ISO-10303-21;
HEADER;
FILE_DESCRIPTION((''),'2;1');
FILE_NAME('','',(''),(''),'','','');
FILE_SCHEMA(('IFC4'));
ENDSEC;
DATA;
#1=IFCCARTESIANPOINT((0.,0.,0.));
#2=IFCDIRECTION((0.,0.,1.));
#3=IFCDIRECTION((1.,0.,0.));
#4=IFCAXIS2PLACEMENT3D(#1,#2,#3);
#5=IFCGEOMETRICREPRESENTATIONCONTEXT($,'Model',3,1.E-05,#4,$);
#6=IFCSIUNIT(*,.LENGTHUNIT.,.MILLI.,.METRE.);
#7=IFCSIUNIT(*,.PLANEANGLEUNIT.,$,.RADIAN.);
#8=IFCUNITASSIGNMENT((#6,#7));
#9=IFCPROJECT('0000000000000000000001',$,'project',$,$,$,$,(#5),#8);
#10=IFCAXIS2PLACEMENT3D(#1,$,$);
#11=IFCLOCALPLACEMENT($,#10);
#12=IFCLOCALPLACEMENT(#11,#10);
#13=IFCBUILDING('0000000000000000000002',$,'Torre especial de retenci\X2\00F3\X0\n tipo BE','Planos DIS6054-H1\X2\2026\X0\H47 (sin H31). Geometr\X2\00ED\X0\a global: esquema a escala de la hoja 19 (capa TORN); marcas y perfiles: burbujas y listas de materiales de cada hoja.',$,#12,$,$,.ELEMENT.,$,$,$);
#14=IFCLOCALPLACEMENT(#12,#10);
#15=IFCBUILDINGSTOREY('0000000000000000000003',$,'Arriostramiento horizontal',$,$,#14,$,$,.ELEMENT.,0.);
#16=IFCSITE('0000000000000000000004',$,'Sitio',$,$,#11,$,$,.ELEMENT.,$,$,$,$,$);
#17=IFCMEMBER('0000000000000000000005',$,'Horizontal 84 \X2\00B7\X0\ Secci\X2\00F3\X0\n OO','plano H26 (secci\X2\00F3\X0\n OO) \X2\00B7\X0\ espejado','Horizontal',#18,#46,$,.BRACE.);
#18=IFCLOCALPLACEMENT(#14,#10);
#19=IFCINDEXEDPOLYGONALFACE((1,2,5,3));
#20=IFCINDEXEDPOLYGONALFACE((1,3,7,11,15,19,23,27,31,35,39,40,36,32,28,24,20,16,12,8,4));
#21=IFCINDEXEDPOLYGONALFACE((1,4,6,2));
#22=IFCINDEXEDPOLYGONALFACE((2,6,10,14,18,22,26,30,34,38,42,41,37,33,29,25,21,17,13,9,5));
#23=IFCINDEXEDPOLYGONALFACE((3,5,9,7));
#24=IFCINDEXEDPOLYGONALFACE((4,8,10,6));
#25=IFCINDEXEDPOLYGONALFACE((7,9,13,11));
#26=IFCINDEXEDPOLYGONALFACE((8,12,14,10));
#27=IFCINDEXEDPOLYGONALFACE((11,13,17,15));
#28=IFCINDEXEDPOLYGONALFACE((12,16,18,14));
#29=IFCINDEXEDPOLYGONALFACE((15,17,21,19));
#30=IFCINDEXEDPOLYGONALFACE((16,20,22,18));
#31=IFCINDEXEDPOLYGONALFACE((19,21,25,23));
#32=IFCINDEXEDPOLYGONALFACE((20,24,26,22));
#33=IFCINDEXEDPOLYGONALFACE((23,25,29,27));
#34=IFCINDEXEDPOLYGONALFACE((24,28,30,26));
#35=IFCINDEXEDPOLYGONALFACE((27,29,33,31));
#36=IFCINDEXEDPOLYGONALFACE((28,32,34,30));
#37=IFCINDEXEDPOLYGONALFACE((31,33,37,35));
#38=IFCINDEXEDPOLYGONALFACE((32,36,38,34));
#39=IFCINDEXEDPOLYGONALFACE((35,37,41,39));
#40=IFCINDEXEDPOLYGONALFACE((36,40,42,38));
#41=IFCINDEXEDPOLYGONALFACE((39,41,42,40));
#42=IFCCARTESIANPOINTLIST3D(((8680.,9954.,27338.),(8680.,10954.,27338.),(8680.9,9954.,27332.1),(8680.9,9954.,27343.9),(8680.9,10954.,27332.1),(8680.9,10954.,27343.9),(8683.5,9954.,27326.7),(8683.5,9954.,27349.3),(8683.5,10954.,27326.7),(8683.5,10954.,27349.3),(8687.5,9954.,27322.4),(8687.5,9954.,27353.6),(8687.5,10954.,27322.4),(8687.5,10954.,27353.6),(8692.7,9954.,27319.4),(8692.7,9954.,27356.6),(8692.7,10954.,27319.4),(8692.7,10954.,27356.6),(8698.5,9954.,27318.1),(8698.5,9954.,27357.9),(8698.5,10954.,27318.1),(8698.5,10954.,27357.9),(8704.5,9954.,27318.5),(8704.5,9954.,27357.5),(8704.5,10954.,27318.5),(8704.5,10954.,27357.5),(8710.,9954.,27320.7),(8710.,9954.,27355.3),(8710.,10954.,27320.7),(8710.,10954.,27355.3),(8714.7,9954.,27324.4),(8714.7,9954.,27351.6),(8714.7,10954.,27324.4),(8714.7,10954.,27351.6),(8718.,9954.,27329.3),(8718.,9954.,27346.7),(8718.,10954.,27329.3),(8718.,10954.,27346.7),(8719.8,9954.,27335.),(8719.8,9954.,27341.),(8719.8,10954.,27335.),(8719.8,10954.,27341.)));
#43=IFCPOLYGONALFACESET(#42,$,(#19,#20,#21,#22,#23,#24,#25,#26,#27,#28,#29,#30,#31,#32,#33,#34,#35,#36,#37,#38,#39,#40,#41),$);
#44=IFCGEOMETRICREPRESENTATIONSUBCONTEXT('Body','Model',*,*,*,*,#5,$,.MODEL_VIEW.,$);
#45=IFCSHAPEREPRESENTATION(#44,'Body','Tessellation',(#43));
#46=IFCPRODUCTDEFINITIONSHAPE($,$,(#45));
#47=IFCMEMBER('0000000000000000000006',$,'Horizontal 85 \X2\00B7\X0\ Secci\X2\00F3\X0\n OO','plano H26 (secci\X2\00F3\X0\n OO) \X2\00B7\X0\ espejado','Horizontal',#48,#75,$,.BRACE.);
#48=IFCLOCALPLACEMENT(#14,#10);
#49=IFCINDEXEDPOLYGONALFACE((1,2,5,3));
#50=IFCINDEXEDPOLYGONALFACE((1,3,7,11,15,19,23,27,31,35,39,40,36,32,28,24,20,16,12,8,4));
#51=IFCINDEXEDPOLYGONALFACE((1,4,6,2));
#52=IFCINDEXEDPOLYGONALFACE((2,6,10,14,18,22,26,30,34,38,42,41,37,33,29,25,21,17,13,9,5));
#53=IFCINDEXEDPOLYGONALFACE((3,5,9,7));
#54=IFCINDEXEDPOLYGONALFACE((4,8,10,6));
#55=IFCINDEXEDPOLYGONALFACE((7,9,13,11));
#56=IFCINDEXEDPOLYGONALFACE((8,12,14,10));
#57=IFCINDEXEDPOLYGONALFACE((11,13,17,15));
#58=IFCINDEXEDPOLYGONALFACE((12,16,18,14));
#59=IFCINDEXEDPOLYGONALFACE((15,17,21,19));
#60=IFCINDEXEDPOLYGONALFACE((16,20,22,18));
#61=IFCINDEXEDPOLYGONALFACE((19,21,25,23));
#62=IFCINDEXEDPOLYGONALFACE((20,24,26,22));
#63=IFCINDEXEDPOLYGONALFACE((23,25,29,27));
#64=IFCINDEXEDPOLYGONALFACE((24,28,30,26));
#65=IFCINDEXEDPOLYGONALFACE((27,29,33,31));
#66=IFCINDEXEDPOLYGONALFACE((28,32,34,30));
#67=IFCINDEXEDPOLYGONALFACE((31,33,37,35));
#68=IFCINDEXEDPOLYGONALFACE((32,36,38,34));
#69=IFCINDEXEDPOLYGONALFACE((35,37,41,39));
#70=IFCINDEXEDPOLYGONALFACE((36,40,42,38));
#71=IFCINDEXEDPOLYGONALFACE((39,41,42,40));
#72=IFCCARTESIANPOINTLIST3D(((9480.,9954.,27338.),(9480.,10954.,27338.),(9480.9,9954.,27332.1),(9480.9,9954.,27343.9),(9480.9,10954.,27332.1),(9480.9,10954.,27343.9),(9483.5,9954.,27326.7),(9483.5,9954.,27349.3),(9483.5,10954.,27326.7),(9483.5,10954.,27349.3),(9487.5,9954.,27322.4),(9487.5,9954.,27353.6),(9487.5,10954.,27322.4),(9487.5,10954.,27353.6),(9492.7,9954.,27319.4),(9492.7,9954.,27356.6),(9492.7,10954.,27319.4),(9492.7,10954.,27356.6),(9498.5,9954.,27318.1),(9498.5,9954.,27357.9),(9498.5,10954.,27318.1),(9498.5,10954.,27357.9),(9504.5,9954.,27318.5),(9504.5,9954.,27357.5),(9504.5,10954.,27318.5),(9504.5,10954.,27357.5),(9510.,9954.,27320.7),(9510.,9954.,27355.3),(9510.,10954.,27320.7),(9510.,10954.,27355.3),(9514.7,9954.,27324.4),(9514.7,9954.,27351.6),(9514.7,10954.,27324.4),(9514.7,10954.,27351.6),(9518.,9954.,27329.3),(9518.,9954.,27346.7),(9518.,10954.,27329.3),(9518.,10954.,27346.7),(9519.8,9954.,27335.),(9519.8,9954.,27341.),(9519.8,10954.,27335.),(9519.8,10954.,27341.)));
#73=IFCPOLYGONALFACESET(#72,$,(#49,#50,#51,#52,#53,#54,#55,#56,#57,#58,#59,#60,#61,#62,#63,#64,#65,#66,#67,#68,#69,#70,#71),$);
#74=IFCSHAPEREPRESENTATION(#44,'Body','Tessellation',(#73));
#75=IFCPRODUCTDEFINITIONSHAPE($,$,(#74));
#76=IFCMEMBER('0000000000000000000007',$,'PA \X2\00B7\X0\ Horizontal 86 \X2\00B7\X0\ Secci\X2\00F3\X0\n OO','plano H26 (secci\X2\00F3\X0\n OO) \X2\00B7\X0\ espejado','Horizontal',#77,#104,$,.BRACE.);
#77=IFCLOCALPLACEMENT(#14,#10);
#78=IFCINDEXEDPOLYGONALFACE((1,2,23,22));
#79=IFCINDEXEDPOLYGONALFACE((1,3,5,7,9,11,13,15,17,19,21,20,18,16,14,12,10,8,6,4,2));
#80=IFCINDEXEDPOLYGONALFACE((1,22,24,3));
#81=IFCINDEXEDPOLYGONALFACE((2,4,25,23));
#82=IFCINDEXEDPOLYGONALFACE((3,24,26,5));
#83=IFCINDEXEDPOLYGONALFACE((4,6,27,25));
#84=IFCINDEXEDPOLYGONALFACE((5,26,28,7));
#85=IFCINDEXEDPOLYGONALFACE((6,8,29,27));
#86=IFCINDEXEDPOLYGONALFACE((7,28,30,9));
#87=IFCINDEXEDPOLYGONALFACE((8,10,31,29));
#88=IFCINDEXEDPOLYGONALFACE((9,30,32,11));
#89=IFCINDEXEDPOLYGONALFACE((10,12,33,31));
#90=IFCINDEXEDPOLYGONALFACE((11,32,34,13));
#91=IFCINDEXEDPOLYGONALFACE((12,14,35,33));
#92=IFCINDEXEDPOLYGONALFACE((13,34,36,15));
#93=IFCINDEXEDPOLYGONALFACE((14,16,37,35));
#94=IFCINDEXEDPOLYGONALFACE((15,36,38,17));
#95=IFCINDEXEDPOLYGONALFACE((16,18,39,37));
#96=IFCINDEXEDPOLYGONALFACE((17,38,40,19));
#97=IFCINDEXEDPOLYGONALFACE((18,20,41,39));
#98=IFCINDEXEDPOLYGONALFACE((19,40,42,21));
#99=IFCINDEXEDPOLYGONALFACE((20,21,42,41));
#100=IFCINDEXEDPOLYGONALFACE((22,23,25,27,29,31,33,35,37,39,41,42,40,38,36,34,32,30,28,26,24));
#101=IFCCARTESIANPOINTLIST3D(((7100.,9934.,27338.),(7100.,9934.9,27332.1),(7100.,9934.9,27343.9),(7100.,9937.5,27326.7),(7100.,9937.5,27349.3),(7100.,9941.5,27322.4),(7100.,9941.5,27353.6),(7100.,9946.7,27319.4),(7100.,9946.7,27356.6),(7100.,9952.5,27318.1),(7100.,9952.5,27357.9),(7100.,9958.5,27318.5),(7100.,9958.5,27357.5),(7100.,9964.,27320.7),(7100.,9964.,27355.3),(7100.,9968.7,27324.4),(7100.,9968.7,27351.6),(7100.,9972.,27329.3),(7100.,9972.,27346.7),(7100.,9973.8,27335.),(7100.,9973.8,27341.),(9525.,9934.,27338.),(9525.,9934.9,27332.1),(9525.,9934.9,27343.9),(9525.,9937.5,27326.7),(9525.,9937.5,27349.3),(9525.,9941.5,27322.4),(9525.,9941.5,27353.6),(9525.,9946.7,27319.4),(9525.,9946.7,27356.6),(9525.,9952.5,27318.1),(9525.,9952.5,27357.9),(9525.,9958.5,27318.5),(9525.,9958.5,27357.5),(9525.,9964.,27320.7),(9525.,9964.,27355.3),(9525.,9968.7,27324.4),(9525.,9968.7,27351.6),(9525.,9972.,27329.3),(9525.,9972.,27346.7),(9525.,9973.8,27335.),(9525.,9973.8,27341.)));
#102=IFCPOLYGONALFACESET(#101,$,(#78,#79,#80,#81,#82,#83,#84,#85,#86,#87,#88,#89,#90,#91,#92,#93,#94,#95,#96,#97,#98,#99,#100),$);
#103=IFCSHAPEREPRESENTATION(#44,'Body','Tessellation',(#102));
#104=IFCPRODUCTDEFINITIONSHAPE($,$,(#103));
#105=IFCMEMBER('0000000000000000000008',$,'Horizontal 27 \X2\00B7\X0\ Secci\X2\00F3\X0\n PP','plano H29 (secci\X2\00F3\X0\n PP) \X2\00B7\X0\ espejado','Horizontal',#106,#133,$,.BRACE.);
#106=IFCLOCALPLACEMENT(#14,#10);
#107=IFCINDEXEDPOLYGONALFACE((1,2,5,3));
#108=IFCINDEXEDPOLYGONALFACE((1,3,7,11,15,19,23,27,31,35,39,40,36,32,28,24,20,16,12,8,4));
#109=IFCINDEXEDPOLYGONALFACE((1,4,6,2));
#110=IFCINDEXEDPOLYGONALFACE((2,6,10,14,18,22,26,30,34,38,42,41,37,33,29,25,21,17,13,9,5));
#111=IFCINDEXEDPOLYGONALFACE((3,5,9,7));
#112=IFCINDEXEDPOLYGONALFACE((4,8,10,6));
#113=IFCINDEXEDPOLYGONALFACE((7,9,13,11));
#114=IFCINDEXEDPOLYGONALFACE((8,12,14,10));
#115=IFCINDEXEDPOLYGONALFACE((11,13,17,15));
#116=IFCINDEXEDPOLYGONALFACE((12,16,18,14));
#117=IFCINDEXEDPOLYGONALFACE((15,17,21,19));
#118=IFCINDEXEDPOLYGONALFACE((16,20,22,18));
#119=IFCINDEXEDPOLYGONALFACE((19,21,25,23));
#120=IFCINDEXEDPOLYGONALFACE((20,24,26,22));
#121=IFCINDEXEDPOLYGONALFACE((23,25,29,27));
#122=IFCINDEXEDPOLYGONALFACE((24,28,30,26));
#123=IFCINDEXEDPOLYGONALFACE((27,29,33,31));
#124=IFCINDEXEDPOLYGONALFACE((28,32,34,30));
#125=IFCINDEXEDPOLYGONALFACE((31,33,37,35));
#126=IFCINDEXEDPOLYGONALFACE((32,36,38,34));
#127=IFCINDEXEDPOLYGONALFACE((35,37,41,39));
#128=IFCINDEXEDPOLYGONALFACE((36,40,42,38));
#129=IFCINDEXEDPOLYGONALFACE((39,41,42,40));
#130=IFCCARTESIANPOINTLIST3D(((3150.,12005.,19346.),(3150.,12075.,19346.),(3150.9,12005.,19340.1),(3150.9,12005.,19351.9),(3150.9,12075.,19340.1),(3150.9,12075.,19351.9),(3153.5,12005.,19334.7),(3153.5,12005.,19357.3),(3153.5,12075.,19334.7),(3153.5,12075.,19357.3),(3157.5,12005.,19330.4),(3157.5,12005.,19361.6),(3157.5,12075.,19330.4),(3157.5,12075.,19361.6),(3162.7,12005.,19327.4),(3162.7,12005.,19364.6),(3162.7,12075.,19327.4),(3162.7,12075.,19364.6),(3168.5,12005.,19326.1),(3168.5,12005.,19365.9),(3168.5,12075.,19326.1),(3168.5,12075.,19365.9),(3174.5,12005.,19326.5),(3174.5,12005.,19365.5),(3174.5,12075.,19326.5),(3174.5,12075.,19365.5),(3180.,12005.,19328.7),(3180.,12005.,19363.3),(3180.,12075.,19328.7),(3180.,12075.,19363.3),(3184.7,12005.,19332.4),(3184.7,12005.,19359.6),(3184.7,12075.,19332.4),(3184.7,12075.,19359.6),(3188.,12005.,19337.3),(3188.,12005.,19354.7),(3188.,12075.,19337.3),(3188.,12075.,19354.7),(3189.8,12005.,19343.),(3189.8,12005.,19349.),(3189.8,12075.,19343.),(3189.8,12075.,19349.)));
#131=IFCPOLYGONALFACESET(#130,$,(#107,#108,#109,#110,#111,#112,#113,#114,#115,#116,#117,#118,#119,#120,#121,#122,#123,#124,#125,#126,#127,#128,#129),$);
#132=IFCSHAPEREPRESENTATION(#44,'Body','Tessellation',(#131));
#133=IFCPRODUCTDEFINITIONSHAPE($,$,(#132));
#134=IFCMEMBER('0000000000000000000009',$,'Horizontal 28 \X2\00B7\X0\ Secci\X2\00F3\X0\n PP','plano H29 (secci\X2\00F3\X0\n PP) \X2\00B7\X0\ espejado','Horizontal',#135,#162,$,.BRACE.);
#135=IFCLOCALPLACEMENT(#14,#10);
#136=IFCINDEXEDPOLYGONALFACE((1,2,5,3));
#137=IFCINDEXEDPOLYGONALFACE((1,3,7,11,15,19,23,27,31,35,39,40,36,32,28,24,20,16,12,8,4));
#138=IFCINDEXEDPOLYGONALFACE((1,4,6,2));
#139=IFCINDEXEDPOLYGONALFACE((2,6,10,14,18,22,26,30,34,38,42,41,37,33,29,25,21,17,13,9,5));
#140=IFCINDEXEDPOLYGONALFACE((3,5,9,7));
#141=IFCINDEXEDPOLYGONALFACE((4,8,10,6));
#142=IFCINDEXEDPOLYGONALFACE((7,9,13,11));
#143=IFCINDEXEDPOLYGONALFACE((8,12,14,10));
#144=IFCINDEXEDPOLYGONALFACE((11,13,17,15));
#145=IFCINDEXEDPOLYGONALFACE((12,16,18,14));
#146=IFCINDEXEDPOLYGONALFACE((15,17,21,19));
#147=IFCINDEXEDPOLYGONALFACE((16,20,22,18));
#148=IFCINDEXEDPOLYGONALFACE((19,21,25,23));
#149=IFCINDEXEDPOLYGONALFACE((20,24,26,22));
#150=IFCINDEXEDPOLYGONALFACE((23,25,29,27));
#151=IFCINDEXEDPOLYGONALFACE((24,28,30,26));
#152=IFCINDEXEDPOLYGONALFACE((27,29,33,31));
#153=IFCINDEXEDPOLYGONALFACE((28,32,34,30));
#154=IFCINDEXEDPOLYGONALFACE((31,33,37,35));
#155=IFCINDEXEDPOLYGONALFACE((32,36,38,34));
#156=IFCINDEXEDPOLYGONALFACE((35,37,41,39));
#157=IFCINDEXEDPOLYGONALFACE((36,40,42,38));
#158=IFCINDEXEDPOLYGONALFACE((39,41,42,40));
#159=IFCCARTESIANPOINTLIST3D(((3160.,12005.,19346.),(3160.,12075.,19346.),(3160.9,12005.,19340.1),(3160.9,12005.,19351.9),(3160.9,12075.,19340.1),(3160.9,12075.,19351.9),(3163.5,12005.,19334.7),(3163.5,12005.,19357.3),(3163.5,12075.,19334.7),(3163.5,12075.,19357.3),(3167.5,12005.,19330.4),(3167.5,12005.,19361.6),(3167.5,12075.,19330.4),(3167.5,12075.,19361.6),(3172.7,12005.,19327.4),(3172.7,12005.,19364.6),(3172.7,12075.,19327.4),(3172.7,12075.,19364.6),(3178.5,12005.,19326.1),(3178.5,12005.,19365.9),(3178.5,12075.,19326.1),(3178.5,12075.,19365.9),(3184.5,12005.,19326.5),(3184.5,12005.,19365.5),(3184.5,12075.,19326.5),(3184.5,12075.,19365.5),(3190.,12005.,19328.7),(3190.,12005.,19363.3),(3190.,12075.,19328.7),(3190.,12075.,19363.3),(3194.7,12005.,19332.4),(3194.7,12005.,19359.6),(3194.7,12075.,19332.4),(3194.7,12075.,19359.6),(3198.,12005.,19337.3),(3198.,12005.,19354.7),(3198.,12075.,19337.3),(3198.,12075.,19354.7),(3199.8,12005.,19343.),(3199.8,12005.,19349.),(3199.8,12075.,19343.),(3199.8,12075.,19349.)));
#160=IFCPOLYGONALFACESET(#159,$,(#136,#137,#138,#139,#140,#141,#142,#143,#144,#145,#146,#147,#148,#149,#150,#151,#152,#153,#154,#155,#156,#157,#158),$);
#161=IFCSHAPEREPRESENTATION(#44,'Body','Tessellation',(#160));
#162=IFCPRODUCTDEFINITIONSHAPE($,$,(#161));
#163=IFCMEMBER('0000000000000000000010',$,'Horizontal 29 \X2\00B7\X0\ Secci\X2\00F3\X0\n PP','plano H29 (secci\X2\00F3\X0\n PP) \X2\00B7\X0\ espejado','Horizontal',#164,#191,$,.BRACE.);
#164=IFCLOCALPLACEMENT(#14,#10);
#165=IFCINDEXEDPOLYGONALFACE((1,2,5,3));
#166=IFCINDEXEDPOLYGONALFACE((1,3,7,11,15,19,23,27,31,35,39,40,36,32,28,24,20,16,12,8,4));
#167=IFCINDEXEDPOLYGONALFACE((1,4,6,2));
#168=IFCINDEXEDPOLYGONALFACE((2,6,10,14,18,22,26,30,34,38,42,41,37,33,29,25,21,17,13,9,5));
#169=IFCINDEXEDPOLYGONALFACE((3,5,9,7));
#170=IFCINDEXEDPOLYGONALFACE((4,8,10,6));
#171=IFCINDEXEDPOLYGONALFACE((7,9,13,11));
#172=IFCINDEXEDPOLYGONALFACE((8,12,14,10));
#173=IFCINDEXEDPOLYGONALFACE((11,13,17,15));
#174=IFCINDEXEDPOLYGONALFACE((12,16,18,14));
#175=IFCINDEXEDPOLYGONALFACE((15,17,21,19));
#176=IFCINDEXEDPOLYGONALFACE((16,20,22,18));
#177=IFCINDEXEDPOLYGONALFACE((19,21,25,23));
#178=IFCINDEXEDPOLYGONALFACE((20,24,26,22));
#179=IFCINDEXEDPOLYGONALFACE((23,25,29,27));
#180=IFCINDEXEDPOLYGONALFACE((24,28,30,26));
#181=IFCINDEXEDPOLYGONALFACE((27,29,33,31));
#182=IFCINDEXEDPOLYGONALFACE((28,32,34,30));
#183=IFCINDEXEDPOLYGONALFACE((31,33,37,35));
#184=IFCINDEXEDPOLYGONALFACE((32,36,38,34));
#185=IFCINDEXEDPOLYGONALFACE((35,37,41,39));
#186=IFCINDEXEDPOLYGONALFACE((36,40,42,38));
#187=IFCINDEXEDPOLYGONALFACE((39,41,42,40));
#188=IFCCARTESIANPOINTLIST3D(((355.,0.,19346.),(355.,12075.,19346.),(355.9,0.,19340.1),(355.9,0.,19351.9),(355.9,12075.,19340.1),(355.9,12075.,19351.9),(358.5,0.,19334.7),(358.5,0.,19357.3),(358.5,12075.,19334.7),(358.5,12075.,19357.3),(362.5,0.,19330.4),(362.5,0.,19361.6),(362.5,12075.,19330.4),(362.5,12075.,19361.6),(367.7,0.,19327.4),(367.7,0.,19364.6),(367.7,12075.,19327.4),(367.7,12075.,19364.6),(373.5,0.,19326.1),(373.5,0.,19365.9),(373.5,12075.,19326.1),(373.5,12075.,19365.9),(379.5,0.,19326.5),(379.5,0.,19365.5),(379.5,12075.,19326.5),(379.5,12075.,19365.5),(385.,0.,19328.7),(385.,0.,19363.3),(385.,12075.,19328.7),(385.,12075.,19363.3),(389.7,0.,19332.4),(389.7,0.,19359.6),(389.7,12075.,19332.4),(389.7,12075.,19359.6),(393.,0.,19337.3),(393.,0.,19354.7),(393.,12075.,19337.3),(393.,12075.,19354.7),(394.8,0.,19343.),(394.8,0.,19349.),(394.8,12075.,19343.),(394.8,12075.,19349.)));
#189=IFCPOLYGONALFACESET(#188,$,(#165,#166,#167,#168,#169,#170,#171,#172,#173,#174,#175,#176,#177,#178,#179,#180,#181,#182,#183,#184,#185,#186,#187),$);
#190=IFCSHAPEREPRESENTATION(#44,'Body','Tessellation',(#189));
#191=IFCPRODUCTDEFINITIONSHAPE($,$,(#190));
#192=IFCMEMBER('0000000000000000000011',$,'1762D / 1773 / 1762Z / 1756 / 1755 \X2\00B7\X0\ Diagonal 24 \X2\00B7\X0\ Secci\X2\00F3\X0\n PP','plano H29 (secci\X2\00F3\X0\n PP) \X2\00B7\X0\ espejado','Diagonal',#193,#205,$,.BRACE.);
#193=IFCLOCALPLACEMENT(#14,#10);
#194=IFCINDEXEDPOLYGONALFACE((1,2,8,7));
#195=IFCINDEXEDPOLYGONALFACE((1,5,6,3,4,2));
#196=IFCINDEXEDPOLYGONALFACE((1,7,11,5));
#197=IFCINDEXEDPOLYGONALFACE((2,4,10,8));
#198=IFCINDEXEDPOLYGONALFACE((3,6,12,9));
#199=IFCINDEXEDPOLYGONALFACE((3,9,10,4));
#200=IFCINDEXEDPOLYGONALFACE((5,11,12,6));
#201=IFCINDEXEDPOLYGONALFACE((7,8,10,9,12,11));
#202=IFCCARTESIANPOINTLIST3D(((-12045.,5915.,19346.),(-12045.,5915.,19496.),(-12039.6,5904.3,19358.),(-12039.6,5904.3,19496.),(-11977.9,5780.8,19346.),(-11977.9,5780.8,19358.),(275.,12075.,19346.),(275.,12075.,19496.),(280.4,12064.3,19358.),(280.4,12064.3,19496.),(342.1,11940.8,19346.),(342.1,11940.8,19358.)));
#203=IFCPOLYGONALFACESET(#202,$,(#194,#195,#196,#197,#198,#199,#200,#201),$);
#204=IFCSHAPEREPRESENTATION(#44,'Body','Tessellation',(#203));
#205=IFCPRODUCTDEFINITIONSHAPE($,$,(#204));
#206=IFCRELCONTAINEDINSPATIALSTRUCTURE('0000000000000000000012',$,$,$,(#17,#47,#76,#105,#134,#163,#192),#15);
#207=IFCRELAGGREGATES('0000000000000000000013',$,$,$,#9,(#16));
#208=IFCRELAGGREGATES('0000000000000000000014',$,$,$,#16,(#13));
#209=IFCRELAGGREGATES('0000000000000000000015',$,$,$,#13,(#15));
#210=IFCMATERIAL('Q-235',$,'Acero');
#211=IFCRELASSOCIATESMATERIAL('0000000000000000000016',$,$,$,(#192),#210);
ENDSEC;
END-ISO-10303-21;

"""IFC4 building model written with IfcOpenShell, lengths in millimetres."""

from ifc_helpers import new_model, si_unit, frame, frame_2d, origin, origin_with_axes, place, context, subcontext, project, spatial, circle, l_section, extrude, material, element, save


model = new_model("IFC4")

# Units and contexts
model_context = context("Model", 3, precision=1e-05, world=origin_with_axes())
body_context = subcontext(model_context, "Body", "Model", "MODEL_VIEW")
ifc_project = project(units=[si_unit("LENGTHUNIT", "METRE", prefix="MILLI"), si_unit("PLANEANGLEUNIT", "RADIAN")], contexts=[model_context])

# Site, building, storey
site_placement = place(None, origin())
site = spatial("IfcSite", under=ifc_project, at=site_placement, Name="Sitio", CompositionType="ELEMENT")
building_placement = place(site_placement, origin())
building = spatial("IfcBuilding", under=site, at=building_placement, Name="Torre especial de retención tipo BE", Description="Planos DIS6054-H1…H47 (sin H31). Geometría global: esquema a escala de la hoja 19 (capa TORN); marcas y perfiles: burbujas y listas de materiales de cada hoja.", CompositionType="ELEMENT")
storey_placement = place(building_placement, origin())
storey = spatial("IfcBuildingStorey", under=building, at=storey_placement, Name="Arriostramiento horizontal", CompositionType="ELEMENT", Elevation=0.0)

# Members
ifc_material = material(Name="Q-235", Category="Acero")
for number, where, z_axis, x_axis, name in (
    (1, (8700.0, 9954.0, 27338.0), (0.0, 1.0, 0.0), (-1.0, 0.0, 0.0), "Horizontal 84 · Sección OO"),
    (2, (9500.0, 9954.0, 27338.0), (0.0, 1.0, 0.0), (-1.0, 0.0, 0.0), "Horizontal 85 · Sección OO"),
):
    element("IfcMember", number, at=place(storey_placement, frame(where, z_axis=z_axis, x_axis=x_axis)), inside=storey, Name=name, Description="plano H26 (sección OO) · espejado", ObjectType="Horizontal", PredefinedType="BRACE", context=body_context, shape_type="SweptSolid", body=[
        extrude(circle(Radius=20.0), None, (0.0, 0.0, 1.0), 1000.0),
    ])
member_1_placement = place(storey_placement, frame((9525.0, 9954.0, 27338.0), z_axis=(-1.0, 0.0, 0.0), x_axis=(0.0, -1.0, 0.0)))
element("IfcMember", 3, at=member_1_placement, inside=storey, Name="PA · Horizontal 86 · Sección OO", Description="plano H26 (sección OO) · espejado", ObjectType="Horizontal", PredefinedType="BRACE", context=body_context, shape_type="SweptSolid", body=[
    extrude(circle(Radius=20.0), None, (0.0, 0.0, 1.0), 2425.0),
])
for number, where, z_axis, x_axis, name in (
    (4, (3170.0, 12075.0, 19346.0), (0.0, -1.0, 0.0), (-1.0, 0.0, 0.0), "Horizontal 27 · Sección PP"),
    (5, (3180.0, 12075.0, 19346.0), (0.0, -1.0, 0.0), (-1.0, 0.0, 0.0), "Horizontal 28 · Sección PP"),
):
    element("IfcMember", number, at=place(storey_placement, frame(where, z_axis=z_axis, x_axis=x_axis)), inside=storey, Name=name, Description="plano H29 (sección PP) · espejado", ObjectType="Horizontal", PredefinedType="BRACE", context=body_context, shape_type="SweptSolid", body=[
        extrude(circle(Radius=20.0), None, (0.0, 0.0, 1.0), 70.0),
    ])
member_2_placement = place(storey_placement, frame((375.0, 12075.0, 19346.0), z_axis=(0.0, -1.0, 0.0), x_axis=(-1.0, 0.0, 0.0)))
element("IfcMember", 6, at=member_2_placement, inside=storey, Name="Horizontal 29 · Sección PP", Description="plano H29 (sección PP) · espejado", ObjectType="Horizontal", PredefinedType="BRACE", context=body_context, shape_type="SweptSolid", body=[
    extrude(circle(Radius=20.0), None, (0.0, 0.0, 1.0), 12075.0),
])
member_3_placement = place(storey_placement, frame((275.0, 12075.0, 19346.0), z_axis=(-0.894427, -0.447214, 0.0), x_axis=(0.447214, -0.894427, 0.0)))
element("IfcMember", 7, at=member_3_placement, inside=storey, material=ifc_material, Name="1762D / 1773 / 1762Z / 1756 / 1755 · Diagonal 24 · Sección PP", Description="plano H29 (sección PP) · espejado", ObjectType="Diagonal", PredefinedType="BRACE", context=body_context, shape_type="SweptSolid", body=[
    extrude(l_section(Depth=150.0, Width=150.0, Thickness=12.0, at=frame_2d((75.0, 75.0))), None, (0.0, 0.0, 1.0), 13774.2),
])

save(model, "model.ifc")
